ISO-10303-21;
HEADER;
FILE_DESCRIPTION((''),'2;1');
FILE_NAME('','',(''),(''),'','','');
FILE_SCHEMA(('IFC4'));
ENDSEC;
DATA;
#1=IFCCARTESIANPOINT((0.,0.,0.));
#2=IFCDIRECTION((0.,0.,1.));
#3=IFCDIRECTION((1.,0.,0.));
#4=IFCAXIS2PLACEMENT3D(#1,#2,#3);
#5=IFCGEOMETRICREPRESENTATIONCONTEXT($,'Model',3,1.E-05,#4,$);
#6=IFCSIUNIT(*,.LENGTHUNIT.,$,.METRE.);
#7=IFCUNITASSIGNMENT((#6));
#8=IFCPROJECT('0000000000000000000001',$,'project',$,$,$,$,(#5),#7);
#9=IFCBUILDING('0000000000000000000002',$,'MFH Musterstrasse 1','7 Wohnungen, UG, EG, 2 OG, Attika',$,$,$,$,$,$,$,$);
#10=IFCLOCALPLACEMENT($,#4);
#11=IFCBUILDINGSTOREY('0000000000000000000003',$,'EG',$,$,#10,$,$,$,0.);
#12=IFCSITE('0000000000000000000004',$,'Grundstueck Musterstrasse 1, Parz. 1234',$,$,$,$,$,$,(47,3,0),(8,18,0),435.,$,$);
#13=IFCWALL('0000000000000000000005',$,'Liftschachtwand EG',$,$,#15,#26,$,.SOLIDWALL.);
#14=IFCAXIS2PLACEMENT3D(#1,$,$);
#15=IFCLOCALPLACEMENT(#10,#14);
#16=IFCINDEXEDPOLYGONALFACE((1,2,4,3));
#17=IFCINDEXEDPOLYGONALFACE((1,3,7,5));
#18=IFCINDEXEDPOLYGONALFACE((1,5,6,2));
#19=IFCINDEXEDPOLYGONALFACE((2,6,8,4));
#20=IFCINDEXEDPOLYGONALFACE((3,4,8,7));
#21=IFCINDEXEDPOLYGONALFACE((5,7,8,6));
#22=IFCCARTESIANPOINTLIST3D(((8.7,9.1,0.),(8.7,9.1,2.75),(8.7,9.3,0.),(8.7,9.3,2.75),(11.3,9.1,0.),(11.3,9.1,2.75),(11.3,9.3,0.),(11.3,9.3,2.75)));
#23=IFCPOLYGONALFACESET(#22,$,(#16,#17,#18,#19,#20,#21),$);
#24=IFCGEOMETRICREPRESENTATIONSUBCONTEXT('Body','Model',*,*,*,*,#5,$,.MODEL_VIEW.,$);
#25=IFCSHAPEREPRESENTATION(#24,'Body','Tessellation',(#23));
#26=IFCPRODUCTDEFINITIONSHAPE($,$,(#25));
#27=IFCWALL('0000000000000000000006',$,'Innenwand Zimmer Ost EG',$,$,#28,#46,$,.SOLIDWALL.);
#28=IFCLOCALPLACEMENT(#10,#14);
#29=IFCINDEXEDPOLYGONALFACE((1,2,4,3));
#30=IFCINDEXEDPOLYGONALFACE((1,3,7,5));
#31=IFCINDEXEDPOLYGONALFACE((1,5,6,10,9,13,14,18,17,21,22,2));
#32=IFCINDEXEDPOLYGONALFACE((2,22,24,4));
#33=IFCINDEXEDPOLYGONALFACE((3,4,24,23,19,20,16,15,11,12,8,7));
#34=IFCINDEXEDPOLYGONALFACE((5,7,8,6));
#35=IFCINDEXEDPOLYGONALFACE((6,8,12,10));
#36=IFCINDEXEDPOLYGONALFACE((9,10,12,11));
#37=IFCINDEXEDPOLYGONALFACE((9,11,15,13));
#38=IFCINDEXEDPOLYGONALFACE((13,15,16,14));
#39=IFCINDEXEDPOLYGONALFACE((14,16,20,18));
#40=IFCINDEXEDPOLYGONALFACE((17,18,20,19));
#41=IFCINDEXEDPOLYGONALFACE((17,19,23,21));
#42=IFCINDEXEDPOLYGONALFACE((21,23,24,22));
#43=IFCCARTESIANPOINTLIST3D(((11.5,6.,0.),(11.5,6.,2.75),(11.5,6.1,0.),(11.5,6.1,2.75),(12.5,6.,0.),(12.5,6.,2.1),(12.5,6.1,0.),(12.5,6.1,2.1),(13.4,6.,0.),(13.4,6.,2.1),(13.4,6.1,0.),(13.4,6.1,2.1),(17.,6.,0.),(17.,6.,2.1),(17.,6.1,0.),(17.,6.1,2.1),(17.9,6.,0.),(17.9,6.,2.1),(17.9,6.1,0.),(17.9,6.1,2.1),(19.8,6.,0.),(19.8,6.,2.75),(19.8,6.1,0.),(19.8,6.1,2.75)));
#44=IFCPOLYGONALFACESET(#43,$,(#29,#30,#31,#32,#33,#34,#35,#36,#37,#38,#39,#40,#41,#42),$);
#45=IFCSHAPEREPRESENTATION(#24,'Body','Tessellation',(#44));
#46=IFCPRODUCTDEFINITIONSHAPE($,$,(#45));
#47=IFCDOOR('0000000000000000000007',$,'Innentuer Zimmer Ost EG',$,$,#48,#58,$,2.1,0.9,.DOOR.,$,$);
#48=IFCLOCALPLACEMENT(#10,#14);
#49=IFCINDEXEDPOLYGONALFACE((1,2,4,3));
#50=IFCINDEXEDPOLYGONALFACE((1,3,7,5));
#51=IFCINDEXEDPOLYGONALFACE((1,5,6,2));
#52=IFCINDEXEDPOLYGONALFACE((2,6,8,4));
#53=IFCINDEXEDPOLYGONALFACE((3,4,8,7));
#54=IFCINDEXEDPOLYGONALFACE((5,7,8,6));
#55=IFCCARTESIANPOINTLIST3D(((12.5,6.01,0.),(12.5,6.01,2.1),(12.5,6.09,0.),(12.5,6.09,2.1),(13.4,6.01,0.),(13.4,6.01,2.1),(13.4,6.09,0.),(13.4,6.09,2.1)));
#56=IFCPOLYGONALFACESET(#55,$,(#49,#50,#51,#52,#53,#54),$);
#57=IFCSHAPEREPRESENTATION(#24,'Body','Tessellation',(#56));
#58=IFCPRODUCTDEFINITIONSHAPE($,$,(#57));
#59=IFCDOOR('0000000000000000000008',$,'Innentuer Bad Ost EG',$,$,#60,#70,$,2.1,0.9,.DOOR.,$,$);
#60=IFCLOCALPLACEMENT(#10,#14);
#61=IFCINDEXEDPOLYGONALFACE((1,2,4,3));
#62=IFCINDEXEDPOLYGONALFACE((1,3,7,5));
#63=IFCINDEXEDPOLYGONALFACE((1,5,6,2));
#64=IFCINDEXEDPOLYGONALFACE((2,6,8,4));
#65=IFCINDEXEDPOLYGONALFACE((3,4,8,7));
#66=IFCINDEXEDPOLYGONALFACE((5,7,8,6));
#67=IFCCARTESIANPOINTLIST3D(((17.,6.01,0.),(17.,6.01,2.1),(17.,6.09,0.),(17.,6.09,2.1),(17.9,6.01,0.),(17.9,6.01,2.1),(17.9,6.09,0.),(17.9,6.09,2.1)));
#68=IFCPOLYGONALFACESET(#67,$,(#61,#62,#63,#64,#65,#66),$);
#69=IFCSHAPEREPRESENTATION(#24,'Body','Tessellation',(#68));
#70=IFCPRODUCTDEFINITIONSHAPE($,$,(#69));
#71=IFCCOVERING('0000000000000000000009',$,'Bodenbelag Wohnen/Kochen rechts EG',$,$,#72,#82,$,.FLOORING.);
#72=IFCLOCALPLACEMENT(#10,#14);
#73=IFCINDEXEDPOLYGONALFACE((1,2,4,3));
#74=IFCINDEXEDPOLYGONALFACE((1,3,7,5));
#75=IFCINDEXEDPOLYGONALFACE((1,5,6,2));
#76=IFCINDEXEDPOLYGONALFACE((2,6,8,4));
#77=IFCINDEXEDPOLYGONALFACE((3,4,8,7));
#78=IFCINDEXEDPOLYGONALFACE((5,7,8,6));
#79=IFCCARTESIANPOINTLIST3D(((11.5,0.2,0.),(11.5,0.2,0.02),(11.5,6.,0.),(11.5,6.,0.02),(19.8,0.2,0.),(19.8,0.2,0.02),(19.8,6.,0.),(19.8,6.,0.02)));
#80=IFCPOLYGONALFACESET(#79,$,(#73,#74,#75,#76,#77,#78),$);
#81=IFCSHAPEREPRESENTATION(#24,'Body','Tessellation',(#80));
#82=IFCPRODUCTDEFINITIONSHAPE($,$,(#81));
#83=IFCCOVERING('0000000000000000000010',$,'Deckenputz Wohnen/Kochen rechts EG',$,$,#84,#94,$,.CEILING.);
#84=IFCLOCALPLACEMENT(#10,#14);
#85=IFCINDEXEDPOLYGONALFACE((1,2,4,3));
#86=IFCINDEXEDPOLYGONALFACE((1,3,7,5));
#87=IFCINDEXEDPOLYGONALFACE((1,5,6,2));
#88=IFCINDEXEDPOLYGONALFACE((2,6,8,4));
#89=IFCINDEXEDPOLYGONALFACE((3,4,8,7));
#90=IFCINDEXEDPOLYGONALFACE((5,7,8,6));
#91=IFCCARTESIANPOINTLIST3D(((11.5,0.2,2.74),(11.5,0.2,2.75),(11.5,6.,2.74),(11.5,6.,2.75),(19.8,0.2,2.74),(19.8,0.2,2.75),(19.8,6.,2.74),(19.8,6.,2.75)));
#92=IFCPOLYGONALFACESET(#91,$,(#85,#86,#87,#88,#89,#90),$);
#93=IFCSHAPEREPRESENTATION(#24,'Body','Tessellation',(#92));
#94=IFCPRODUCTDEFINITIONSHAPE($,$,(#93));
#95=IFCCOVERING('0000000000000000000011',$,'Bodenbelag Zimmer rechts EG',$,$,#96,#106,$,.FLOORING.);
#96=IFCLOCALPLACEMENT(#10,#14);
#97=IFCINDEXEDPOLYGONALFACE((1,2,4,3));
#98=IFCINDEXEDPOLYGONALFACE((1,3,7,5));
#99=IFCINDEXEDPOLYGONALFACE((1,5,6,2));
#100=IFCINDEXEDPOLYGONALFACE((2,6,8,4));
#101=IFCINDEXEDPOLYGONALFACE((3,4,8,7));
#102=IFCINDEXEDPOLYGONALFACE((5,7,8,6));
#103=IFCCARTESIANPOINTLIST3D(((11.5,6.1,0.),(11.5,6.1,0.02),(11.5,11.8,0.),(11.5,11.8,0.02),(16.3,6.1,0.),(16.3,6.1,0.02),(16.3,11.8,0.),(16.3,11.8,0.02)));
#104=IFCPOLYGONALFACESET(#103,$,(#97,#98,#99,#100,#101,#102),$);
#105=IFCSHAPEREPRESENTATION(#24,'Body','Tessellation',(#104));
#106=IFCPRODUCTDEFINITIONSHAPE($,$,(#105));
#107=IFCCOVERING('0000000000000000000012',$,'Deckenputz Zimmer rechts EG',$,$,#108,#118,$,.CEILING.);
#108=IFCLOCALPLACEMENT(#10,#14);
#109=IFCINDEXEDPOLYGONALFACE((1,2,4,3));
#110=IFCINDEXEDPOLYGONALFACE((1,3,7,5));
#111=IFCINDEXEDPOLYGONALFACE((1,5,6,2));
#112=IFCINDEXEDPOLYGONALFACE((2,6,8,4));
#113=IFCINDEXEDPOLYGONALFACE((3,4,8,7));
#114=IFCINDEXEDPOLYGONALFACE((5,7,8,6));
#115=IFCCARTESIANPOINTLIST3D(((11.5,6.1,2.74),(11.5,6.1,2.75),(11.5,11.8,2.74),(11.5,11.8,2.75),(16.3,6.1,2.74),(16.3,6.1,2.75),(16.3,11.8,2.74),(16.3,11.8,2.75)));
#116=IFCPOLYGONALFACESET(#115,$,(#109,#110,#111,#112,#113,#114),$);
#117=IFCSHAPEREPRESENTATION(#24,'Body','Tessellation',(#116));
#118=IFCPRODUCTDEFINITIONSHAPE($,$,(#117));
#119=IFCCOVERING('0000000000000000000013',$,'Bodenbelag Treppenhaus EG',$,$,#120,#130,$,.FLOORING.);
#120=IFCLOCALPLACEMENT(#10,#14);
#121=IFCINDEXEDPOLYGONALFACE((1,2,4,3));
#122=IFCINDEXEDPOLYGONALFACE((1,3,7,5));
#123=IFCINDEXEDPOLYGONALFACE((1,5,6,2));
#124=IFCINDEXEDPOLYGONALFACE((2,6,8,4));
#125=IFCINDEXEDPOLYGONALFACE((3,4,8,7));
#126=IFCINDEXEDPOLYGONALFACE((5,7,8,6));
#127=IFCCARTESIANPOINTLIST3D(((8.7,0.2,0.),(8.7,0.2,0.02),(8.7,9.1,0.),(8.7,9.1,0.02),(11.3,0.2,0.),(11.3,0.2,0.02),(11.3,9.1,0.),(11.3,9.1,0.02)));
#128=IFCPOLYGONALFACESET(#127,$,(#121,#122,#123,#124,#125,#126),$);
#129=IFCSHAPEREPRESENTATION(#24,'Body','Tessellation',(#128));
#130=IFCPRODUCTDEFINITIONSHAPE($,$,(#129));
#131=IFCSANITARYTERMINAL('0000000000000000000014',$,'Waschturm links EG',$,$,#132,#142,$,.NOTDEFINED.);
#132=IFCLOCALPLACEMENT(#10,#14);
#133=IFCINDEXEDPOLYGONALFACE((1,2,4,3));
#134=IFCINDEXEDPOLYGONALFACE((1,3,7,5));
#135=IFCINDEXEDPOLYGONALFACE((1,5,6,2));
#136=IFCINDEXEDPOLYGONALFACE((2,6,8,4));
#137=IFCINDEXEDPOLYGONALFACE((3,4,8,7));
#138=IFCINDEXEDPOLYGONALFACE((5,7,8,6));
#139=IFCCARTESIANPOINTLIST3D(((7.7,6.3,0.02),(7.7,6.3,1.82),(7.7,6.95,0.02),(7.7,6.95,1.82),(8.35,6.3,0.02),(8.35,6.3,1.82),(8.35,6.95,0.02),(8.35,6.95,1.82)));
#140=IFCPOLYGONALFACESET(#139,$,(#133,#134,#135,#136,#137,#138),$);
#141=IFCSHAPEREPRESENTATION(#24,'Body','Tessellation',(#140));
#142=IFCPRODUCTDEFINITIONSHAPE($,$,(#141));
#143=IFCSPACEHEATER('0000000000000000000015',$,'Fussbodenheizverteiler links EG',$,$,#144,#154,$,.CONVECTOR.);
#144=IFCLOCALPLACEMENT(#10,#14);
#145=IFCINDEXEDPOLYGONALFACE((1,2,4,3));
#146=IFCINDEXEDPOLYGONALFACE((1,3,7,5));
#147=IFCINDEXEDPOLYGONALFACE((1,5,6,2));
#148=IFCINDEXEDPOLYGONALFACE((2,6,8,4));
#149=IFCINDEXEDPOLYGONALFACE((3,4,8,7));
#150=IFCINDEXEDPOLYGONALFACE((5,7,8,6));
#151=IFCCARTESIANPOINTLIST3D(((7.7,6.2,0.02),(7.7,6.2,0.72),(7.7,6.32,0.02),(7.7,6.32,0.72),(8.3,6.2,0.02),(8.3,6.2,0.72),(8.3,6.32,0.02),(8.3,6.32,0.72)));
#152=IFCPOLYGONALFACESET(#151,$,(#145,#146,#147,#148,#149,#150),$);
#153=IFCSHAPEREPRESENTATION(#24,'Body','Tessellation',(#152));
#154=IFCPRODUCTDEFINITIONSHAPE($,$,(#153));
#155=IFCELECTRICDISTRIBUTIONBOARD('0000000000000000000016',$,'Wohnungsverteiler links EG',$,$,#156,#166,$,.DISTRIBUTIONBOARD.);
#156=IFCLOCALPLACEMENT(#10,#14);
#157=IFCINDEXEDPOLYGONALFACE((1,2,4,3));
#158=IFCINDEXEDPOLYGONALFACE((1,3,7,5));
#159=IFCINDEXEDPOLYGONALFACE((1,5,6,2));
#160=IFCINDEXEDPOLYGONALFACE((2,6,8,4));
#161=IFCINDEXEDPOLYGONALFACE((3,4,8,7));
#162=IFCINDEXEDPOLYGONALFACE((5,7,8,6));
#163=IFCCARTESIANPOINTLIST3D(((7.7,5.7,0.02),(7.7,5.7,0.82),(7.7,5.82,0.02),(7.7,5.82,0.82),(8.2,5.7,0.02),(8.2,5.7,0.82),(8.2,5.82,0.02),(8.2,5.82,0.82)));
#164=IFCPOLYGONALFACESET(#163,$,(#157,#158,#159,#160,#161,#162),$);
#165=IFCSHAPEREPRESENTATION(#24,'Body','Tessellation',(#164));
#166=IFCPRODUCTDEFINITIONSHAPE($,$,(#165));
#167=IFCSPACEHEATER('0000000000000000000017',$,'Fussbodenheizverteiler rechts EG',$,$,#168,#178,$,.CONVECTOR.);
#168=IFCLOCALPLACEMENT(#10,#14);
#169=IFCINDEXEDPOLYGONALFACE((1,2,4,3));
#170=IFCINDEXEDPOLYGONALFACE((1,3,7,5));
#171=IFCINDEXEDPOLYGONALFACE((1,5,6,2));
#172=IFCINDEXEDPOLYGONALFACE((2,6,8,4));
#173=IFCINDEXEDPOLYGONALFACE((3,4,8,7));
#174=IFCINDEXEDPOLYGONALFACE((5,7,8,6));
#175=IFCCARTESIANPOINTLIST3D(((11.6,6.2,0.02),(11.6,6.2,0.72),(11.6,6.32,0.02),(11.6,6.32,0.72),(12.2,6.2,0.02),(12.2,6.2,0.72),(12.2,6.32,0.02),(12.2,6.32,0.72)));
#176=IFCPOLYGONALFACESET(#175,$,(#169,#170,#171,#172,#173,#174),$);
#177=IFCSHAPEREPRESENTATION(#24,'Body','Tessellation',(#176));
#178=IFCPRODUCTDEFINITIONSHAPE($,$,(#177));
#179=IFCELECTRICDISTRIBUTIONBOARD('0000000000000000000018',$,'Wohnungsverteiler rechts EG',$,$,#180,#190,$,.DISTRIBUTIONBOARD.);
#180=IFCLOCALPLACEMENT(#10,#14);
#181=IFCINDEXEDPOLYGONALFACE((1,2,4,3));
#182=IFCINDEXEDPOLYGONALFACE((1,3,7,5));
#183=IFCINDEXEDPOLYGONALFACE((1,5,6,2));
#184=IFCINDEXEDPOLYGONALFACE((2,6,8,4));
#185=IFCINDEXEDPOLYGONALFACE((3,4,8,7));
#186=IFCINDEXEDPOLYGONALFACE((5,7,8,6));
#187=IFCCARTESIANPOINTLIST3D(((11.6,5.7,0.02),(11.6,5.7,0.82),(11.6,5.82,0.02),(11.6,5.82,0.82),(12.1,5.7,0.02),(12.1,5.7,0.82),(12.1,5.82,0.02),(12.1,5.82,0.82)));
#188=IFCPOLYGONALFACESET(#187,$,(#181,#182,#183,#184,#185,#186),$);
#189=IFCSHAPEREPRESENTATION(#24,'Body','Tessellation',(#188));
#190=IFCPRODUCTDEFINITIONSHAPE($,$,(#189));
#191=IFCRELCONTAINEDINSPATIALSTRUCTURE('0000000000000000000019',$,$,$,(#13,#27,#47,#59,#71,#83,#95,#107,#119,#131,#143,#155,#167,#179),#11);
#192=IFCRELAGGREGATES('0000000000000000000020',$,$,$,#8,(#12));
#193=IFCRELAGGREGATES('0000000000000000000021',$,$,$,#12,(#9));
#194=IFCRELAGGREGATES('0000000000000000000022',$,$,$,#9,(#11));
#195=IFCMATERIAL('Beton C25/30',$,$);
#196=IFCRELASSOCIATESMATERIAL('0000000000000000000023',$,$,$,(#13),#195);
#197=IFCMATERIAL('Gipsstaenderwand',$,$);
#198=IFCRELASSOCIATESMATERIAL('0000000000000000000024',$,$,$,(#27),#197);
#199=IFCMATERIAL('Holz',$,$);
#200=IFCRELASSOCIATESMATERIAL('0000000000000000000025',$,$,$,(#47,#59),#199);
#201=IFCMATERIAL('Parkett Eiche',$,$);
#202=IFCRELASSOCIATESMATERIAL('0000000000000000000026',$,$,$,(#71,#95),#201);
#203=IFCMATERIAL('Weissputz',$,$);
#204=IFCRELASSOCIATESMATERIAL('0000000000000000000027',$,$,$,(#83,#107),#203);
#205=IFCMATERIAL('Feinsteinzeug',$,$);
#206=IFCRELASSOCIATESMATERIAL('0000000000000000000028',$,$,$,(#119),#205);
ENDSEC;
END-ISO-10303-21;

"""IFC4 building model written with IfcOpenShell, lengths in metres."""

from ifc_helpers import new_model, si_unit, frame, frame_2d, origin_with_axes, place, context, subcontext, project, spatial, rectangle, extrude, material, element, fill, save


model = new_model("IFC4")

# Units and contexts
model_context = context("Model", 3, precision=1e-05, world=origin_with_axes())
body_context = subcontext(model_context, "Body", "Model", "MODEL_VIEW")
ifc_project = project(units=[si_unit("LENGTHUNIT", "METRE")], contexts=[model_context])

# Site, building, storey
site = spatial("IfcSite", under=ifc_project, Name="Grundstueck Musterstrasse 1, Parz. 1234", RefLatitude=(47, 3, 0), RefLongitude=(8, 18, 0), RefElevation=435.0)
building = spatial("IfcBuilding", under=site, Name="MFH Musterstrasse 1", Description="7 Wohnungen, UG, EG, 2 OG, Attika")
storey_placement = place(None, origin_with_axes())
storey = spatial("IfcBuildingStorey", under=building, at=storey_placement, Name="EG", Elevation=0.0)

# Shared definitions
ifc_material_1 = material(Name="Beton C25/30")
ifc_material_2 = material(Name="Holz")

# Wall
wall_1_placement = place(storey_placement, frame((8.7, 9.1, 0.0), z_axis=(0.0, 0.0, 1.0), x_axis=(1.0, 0.0, 0.0)))
element("IfcWall", 1, at=wall_1_placement, inside=storey, material=ifc_material_1, Name="Liftschachtwand EG", PredefinedType="SOLIDWALL", context=body_context, shape_type="SweptSolid", body=[
    extrude(rectangle(XDim=2.6, YDim=0.2, at=frame_2d((1.3, 0.1))), origin_with_axes(), (0.0, 0.0, 1.0), 2.75),
])

# Wall, openings, doors
ifc_material_3 = material(Name="Gipsstaenderwand")
wall_2_placement = place(storey_placement, frame((11.5, 6.0, 0.0), z_axis=(0.0, 0.0, 1.0), x_axis=(1.0, 0.0, 0.0)))
wall_2 = element("IfcWall", 2, at=wall_2_placement, inside=storey, material=ifc_material_3, Name="Innenwand Zimmer Ost EG", PredefinedType="SOLIDWALL", context=body_context, shape_type="SweptSolid", body=[
    extrude(rectangle(XDim=8.3, YDim=0.1, at=frame_2d((4.15, 0.05))), origin_with_axes(), (0.0, 0.0, 1.0), 2.75),
])
opening_1_placement = place(wall_2_placement, frame((1.0, -0.01, 0.0), z_axis=(0.0, 0.0, 1.0), x_axis=(1.0, 0.0, 0.0)))
opening_1 = element("IfcOpeningElement", 3, at=opening_1_placement, cuts=wall_2, context=body_context, shape_type="SweptSolid", body=[
    extrude(rectangle(XDim=0.9, YDim=0.12, at=frame_2d((0.45, 0.06))), origin_with_axes(), (0.0, 0.0, 1.0), 2.1),
])
opening_2_placement = place(wall_2_placement, frame((5.5, -0.01, 0.0), z_axis=(0.0, 0.0, 1.0), x_axis=(1.0, 0.0, 0.0)))
opening_2 = element("IfcOpeningElement", 4, at=opening_2_placement, cuts=wall_2, context=body_context, shape_type="SweptSolid", body=[
    extrude(rectangle(XDim=0.9, YDim=0.12, at=frame_2d((0.45, 0.06))), origin_with_axes(), (0.0, 0.0, 1.0), 2.1),
])
door_1_placement = place(storey_placement, frame((12.5, 6.01, 0.0), z_axis=(0.0, 0.0, 1.0), x_axis=(1.0, 0.0, 0.0)))
door_1 = element("IfcDoor", 5, at=door_1_placement, inside=storey, material=ifc_material_2, Name="Innentuer Zimmer Ost EG", OverallHeight=2.1, OverallWidth=0.9, PredefinedType="DOOR", context=body_context, shape_type="SweptSolid", body=[
    extrude(rectangle(XDim=0.9, YDim=0.08, at=frame_2d((0.45, 0.04))), origin_with_axes(), (0.0, 0.0, 1.0), 2.1),
])
fill(opening_1, door_1)
door_2_placement = place(storey_placement, frame((17.0, 6.01, 0.0), z_axis=(0.0, 0.0, 1.0), x_axis=(1.0, 0.0, 0.0)))
door_2 = element("IfcDoor", 6, at=door_2_placement, inside=storey, material=ifc_material_2, Name="Innentuer Bad Ost EG", OverallHeight=2.1, OverallWidth=0.9, PredefinedType="DOOR", context=body_context, shape_type="SweptSolid", body=[
    extrude(rectangle(XDim=0.9, YDim=0.08, at=frame_2d((0.45, 0.04))), origin_with_axes(), (0.0, 0.0, 1.0), 2.1),
])
fill(opening_2, door_2)

# Coverings
ifc_material_4 = material(Name="Parkett Eiche")
covering_1_placement = place(storey_placement, frame((11.5, 0.2, 0.0), z_axis=(0.0, 0.0, 1.0), x_axis=(1.0, 0.0, 0.0)))
element("IfcCovering", 7, at=covering_1_placement, inside=storey, material=ifc_material_4, Name="Bodenbelag Wohnen/Kochen rechts EG", PredefinedType="FLOORING", context=body_context, shape_type="SweptSolid", body=[
    extrude(rectangle(XDim=8.3, YDim=5.8, at=frame_2d((4.15, 2.9))), origin_with_axes(), (0.0, 0.0, 1.0), 0.02),
])
ifc_material_5 = material(Name="Weissputz")
covering_2_placement = place(storey_placement, frame((11.5, 0.2, 2.74), z_axis=(0.0, 0.0, 1.0), x_axis=(1.0, 0.0, 0.0)))
element("IfcCovering", 8, at=covering_2_placement, inside=storey, material=ifc_material_5, Name="Deckenputz Wohnen/Kochen rechts EG", PredefinedType="CEILING", context=body_context, shape_type="SweptSolid", body=[
    extrude(rectangle(XDim=8.3, YDim=5.8, at=frame_2d((4.15, 2.9))), origin_with_axes(), (0.0, 0.0, 1.0), 0.01),
])
covering_3_placement = place(storey_placement, frame((11.5, 6.1, 0.0), z_axis=(0.0, 0.0, 1.0), x_axis=(1.0, 0.0, 0.0)))
element("IfcCovering", 9, at=covering_3_placement, inside=storey, material=ifc_material_4, Name="Bodenbelag Zimmer rechts EG", PredefinedType="FLOORING", context=body_context, shape_type="SweptSolid", body=[
    extrude(rectangle(XDim=4.8, YDim=5.7, at=frame_2d((2.4, 2.85))), origin_with_axes(), (0.0, 0.0, 1.0), 0.02),
])
covering_4_placement = place(storey_placement, frame((11.5, 6.1, 2.74), z_axis=(0.0, 0.0, 1.0), x_axis=(1.0, 0.0, 0.0)))
element("IfcCovering", 10, at=covering_4_placement, inside=storey, material=ifc_material_5, Name="Deckenputz Zimmer rechts EG", PredefinedType="CEILING", context=body_context, shape_type="SweptSolid", body=[
    extrude(rectangle(XDim=4.8, YDim=5.7, at=frame_2d((2.4, 2.85))), origin_with_axes(), (0.0, 0.0, 1.0), 0.01),
])
ifc_material_6 = material(Name="Feinsteinzeug")
covering_5_placement = place(storey_placement, frame((8.7, 0.2, 0.0), z_axis=(0.0, 0.0, 1.0), x_axis=(1.0, 0.0, 0.0)))
element("IfcCovering", 11, at=covering_5_placement, inside=storey, material=ifc_material_6, Name="Bodenbelag Treppenhaus EG", PredefinedType="FLOORING", context=body_context, shape_type="SweptSolid", body=[
    extrude(rectangle(XDim=2.6, YDim=8.9, at=frame_2d((1.3, 4.45))), origin_with_axes(), (0.0, 0.0, 1.0), 0.02),
])

# Sanitary terminal
sanitary_terminal_placement = place(storey_placement, frame((7.7, 6.3, 0.02), z_axis=(0.0, 0.0, 1.0), x_axis=(1.0, 0.0, 0.0)))
element("IfcSanitaryTerminal", 12, at=sanitary_terminal_placement, inside=storey, Name="Waschturm links EG", PredefinedType="NOTDEFINED", context=body_context, shape_type="SweptSolid", body=[
    extrude(rectangle(XDim=0.65, YDim=0.65, at=frame_2d((0.325, 0.325))), origin_with_axes(), (0.0, 0.0, 1.0), 1.8),
])

# Space heater
space_heater_1_placement = place(storey_placement, frame((7.7, 6.2, 0.02), z_axis=(0.0, 0.0, 1.0), x_axis=(1.0, 0.0, 0.0)))
element("IfcSpaceHeater", 13, at=space_heater_1_placement, inside=storey, Name="Fussbodenheizverteiler links EG", PredefinedType="CONVECTOR", context=body_context, shape_type="SweptSolid", body=[
    extrude(rectangle(XDim=0.6, YDim=0.12, at=frame_2d((0.3, 0.06))), origin_with_axes(), (0.0, 0.0, 1.0), 0.7),
])

# Electric distribution board
electric_distribution_board_1_placement = place(storey_placement, frame((7.7, 5.7, 0.02), z_axis=(0.0, 0.0, 1.0), x_axis=(1.0, 0.0, 0.0)))
element("IfcElectricDistributionBoard", 14, at=electric_distribution_board_1_placement, inside=storey, Name="Wohnungsverteiler links EG", PredefinedType="DISTRIBUTIONBOARD", context=body_context, shape_type="SweptSolid", body=[
    extrude(rectangle(XDim=0.5, YDim=0.12, at=frame_2d((0.25, 0.06))), origin_with_axes(), (0.0, 0.0, 1.0), 0.8),
])

# Space heater
space_heater_2_placement = place(storey_placement, frame((11.6, 6.2, 0.02), z_axis=(0.0, 0.0, 1.0), x_axis=(1.0, 0.0, 0.0)))
element("IfcSpaceHeater", 15, at=space_heater_2_placement, inside=storey, Name="Fussbodenheizverteiler rechts EG", PredefinedType="CONVECTOR", context=body_context, shape_type="SweptSolid", body=[
    extrude(rectangle(XDim=0.6, YDim=0.12, at=frame_2d((0.3, 0.06))), origin_with_axes(), (0.0, 0.0, 1.0), 0.7),
])

# Electric distribution board
electric_distribution_board_2_placement = place(storey_placement, frame((11.6, 5.7, 0.02), z_axis=(0.0, 0.0, 1.0), x_axis=(1.0, 0.0, 0.0)))
element("IfcElectricDistributionBoard", 16, at=electric_distribution_board_2_placement, inside=storey, Name="Wohnungsverteiler rechts EG", PredefinedType="DISTRIBUTIONBOARD", context=body_context, shape_type="SweptSolid", body=[
    extrude(rectangle(XDim=0.5, YDim=0.12, at=frame_2d((0.25, 0.06))), origin_with_axes(), (0.0, 0.0, 1.0), 0.8),
])

save(model, "model.ifc")
